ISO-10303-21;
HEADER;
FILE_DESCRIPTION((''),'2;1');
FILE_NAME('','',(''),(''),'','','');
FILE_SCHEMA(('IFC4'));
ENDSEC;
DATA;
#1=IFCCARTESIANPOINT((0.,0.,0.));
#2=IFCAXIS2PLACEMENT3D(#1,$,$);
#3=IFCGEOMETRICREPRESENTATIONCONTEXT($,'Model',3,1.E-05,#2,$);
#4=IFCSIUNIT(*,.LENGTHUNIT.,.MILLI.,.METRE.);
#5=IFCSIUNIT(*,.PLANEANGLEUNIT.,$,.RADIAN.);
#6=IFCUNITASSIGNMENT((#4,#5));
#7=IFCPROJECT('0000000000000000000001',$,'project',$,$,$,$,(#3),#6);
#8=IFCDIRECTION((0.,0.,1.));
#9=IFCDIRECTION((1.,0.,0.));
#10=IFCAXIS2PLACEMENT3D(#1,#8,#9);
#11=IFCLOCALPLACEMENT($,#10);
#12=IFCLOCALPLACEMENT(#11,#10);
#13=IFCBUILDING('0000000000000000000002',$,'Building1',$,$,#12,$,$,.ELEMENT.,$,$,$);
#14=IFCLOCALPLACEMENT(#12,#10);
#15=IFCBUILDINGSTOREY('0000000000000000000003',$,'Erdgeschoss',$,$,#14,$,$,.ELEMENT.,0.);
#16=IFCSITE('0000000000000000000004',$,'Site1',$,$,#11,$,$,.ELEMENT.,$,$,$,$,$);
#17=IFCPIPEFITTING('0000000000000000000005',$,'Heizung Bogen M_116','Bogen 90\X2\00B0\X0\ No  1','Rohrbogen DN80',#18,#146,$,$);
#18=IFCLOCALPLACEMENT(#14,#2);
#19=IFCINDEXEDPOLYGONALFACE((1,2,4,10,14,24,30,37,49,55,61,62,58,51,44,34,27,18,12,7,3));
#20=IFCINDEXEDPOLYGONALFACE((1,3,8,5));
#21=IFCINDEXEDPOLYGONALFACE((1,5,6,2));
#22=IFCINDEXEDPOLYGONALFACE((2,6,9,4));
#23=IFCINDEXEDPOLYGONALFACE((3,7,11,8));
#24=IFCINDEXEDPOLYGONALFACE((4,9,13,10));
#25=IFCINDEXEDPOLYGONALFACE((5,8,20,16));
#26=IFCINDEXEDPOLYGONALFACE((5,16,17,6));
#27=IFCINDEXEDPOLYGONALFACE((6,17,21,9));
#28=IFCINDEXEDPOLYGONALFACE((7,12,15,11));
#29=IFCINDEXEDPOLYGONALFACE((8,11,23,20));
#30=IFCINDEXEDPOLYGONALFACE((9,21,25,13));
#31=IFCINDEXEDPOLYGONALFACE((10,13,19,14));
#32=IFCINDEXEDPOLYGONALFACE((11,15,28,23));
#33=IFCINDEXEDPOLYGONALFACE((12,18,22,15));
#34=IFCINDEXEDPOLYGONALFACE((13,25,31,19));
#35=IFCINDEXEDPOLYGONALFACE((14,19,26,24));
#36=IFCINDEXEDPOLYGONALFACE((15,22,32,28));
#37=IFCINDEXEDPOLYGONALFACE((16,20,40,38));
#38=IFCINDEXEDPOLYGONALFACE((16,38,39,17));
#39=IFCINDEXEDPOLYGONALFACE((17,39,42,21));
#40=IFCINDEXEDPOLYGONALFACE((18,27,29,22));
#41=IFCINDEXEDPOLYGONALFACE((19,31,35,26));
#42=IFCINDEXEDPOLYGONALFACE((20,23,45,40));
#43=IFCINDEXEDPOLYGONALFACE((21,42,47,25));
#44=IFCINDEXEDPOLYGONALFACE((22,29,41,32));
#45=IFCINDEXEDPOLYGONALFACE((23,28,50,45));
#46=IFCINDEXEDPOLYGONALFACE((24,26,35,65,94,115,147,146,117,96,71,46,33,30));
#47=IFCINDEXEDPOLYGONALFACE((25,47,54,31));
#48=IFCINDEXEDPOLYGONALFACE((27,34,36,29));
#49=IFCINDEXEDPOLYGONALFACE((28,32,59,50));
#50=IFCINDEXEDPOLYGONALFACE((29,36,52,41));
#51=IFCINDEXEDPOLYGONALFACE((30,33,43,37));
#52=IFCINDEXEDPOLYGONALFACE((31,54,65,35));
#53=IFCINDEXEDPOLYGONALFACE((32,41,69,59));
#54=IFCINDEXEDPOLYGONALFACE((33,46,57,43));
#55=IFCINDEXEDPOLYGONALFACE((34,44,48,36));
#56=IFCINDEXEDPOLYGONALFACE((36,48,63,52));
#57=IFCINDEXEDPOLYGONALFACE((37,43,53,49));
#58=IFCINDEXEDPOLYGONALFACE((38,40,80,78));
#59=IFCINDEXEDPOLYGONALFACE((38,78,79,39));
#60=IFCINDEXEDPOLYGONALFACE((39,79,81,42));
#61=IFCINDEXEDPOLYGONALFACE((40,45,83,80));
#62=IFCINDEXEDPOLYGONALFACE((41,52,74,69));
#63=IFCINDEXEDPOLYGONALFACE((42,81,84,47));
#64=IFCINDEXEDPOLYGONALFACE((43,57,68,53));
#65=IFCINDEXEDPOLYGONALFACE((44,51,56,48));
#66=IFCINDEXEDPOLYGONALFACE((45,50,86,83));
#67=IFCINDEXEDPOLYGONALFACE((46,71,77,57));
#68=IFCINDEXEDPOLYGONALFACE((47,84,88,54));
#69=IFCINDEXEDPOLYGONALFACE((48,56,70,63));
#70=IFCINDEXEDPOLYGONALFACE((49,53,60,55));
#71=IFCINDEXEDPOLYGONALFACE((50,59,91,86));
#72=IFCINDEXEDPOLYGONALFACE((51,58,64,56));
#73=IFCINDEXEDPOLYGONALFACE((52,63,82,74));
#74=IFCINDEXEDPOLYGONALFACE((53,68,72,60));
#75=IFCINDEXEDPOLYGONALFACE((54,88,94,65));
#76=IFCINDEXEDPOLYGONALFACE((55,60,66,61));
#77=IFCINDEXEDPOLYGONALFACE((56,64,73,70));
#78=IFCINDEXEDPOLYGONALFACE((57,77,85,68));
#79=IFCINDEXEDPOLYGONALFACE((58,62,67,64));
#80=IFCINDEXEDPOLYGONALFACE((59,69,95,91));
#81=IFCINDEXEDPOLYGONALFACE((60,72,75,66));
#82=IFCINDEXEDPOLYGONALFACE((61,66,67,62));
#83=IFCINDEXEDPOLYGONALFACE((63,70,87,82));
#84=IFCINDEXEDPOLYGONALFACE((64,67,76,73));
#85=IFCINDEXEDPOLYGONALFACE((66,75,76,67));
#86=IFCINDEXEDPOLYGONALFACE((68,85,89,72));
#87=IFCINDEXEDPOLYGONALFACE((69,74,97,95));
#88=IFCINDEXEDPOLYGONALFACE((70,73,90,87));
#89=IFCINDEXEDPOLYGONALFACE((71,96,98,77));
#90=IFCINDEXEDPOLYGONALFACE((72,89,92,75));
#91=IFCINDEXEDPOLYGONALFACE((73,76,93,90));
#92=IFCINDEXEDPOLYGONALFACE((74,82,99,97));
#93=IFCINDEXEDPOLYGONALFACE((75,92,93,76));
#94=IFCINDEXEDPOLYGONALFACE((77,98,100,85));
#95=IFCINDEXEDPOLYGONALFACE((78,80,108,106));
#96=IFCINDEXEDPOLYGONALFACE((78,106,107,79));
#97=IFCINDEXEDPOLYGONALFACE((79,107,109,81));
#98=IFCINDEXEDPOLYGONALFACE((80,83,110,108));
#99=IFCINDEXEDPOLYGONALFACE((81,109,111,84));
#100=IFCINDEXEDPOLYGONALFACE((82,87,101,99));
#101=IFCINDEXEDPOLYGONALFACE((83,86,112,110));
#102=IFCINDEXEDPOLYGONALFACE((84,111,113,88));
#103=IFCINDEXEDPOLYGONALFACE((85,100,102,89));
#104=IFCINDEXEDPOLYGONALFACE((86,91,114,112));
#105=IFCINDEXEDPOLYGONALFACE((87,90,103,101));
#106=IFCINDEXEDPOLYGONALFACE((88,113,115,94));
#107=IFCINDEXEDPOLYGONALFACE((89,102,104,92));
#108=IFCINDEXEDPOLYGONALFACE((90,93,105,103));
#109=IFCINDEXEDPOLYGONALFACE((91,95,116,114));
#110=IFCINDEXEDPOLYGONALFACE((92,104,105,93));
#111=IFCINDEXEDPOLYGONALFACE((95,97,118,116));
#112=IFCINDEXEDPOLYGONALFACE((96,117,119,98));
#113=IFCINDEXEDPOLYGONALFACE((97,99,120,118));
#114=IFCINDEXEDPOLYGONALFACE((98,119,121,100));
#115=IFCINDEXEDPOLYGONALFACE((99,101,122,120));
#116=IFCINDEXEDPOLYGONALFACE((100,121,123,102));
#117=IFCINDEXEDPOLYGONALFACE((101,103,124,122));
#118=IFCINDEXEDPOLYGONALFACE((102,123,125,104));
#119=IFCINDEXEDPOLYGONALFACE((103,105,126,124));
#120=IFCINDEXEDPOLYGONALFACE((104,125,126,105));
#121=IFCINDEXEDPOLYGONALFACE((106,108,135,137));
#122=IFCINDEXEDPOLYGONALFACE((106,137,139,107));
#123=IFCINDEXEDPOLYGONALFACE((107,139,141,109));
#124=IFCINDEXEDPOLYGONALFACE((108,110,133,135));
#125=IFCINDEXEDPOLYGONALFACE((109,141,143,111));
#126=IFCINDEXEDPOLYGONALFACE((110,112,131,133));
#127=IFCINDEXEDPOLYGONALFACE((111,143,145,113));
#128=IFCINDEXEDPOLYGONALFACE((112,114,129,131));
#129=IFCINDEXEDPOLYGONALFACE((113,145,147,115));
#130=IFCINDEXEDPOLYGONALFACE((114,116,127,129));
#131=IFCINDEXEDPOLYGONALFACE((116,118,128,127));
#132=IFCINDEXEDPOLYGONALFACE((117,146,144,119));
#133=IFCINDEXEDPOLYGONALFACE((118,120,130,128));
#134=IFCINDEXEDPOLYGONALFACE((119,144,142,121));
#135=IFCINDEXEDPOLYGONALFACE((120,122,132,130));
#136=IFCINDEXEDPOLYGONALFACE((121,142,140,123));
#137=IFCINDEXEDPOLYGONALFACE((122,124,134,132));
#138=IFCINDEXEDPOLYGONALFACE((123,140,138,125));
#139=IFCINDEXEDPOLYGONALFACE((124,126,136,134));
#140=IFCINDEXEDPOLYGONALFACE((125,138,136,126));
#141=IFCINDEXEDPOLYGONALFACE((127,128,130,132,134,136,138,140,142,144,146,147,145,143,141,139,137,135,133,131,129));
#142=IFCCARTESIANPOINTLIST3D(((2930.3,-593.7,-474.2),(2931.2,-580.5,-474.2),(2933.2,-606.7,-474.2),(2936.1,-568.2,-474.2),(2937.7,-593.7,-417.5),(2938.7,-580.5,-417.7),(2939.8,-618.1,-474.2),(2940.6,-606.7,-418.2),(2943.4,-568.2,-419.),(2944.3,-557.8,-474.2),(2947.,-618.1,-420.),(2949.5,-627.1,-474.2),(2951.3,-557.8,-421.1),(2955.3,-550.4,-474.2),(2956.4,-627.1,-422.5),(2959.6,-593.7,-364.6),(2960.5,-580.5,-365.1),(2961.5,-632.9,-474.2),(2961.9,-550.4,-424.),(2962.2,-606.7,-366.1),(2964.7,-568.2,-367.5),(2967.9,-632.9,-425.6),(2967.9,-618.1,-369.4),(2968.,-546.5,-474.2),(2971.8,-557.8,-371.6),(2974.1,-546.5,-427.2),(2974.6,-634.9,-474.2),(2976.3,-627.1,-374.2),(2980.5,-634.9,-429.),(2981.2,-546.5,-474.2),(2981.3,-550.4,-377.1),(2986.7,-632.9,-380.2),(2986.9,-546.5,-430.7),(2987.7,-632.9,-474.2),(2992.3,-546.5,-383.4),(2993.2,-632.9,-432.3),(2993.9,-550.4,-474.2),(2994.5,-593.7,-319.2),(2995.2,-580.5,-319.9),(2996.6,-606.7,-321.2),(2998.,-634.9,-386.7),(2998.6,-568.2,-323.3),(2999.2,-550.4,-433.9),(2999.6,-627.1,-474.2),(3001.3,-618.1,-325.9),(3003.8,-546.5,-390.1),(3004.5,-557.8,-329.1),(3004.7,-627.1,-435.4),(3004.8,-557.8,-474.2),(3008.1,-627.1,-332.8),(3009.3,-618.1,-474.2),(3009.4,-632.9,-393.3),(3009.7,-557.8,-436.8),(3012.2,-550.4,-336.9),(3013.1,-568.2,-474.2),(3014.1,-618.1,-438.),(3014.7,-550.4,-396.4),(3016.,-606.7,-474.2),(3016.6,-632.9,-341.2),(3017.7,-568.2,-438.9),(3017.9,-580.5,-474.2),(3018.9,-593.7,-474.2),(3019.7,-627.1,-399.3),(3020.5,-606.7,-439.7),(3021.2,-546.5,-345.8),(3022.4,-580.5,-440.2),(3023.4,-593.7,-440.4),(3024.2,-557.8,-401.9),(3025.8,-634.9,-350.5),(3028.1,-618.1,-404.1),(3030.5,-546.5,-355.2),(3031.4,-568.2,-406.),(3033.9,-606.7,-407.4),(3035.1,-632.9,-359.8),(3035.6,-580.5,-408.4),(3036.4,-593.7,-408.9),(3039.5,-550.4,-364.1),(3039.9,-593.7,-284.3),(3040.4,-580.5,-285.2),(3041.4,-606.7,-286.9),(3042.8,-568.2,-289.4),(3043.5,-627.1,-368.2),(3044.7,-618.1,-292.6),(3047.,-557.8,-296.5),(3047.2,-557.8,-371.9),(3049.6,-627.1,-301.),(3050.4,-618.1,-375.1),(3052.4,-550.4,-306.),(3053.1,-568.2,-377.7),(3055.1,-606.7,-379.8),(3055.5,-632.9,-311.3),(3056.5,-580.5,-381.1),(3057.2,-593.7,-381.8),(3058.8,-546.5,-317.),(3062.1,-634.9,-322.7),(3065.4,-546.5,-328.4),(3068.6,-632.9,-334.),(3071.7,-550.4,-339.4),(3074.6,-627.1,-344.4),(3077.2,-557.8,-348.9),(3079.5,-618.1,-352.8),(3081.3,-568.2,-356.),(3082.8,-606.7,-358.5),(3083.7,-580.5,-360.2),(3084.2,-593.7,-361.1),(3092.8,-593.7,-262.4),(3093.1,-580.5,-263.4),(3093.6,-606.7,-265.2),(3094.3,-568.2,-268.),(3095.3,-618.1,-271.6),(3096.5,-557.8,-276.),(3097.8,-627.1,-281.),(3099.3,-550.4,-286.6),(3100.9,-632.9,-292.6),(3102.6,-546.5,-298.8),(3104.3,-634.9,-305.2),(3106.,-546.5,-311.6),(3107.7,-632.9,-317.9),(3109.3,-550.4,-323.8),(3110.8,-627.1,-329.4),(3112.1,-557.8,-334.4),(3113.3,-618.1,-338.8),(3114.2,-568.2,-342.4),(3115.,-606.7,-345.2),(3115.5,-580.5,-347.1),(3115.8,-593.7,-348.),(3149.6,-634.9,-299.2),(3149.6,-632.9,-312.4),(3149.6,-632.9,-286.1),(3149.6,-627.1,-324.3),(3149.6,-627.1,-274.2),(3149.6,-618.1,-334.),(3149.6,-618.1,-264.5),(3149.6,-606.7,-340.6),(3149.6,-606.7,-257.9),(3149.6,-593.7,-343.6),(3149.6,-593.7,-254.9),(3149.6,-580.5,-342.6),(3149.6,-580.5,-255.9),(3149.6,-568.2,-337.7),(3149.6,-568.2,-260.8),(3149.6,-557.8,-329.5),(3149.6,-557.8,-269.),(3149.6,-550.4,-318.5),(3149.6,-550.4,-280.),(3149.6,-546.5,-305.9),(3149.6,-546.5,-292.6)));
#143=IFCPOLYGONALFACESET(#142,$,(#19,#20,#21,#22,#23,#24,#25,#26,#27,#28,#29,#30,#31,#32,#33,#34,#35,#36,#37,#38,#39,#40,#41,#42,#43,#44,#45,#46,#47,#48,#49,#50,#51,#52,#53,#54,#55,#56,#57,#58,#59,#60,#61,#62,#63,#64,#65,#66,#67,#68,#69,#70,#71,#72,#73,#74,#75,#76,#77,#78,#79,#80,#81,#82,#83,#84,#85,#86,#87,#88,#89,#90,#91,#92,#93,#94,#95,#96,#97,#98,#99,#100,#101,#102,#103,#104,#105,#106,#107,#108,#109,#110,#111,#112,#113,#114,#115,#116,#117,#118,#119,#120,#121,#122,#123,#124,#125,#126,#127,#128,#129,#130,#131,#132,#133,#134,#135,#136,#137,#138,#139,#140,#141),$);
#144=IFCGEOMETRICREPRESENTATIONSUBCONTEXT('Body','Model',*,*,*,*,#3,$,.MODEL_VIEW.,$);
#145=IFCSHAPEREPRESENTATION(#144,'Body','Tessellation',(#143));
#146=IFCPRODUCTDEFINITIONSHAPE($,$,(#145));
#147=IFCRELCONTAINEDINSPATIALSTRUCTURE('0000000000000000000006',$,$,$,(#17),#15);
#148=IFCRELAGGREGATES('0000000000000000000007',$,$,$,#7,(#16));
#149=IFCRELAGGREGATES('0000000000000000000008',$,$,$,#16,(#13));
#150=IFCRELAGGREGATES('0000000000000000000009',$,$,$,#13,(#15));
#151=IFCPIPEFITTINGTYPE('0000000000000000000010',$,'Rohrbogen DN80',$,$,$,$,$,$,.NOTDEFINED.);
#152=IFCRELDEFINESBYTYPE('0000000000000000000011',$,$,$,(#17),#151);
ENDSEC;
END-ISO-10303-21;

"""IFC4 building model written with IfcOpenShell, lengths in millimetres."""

from ifc_helpers import new_model, entity, si_unit, frame, origin, origin_with_axes, place, context, subcontext, project, spatial, shape, source, transform, mapped, type_object, element, save


model = new_model("IFC4")

# Units and contexts
model_context = context("Model", 3, precision=1e-05, world=origin())
body_context = subcontext(model_context, "Body", "Model", "MODEL_VIEW")
ifc_project = project(units=[si_unit("LENGTHUNIT", "METRE", prefix="MILLI"), si_unit("PLANEANGLEUNIT", "RADIAN")], contexts=[model_context])

# Site, building, storey
site_placement = place(None, origin_with_axes())
site = spatial("IfcSite", under=ifc_project, at=site_placement, Name="Site1", CompositionType="ELEMENT")
building_placement = place(site_placement, origin_with_axes())
building = spatial("IfcBuilding", under=site, at=building_placement, Name="Building1", CompositionType="ELEMENT")
storey_placement = place(building_placement, origin_with_axes())
storey = spatial("IfcBuildingStorey", under=building, at=storey_placement, Name="Erdgeschoss", CompositionType="ELEMENT", Elevation=0.0)

# Shared definitions
pipe_fitting_type_1 = type_object("IfcPipeFittingType", Name="Rohrbogen DN80", PredefinedType="NOTDEFINED")

# Pipe fitting
shared_shape_1 = source(origin_with_axes(), body_context, "Body", "SolidModel", [
    entity("IfcRevolvedAreaSolid", entity("IfcCircleProfileDef", "AREA", None, entity("IfcAxis2Placement2D", entity("IfcCartesianPoint", [0.0, 0.0]), entity("IfcDirection", [1.0, 0.0])), 44.5), entity("IfcAxis2Placement3D", entity("IfcCartesianPoint", [109.7, -65.3, 0.0]), entity("IfcDirection", [-1.0, 0.0, 0.0]), entity("IfcDirection", [0.0, 0.0, 1.0])), entity("IfcAxis1Placement", entity("IfcCartesianPoint", [0.0, 175.0, 0.0]), entity("IfcDirection", [-1.0, 0.0, 0.0])), 1.570796),
])
pipe_fitting_1_placement = place(storey_placement, frame((3039.9, -590.4, -364.5), z_axis=(0.0, 0.0, 1.0), x_axis=(1.0, 0.0, 0.0)))
element("IfcPipeFitting", 1, at=pipe_fitting_1_placement, inside=storey, type_object=pipe_fitting_type_1, Name="Heizung Bogen M_116", Description="Bogen 90° No  1", ObjectType="Rohrbogen DN80", shapes=[
    shape(body_context, "Body", "MappedRepresentation", [mapped(shared_shape_1, transform((0.0, 0.0, 0.0), x_axis=(0.0, 0.0, -1.0), y_axis=(1.0, 0.0, 0.0), z_axis=(0.0, -1.0, 0.0), scale=1.0))]),
    shape(body_context, "Body", "MappedRepresentation", [mapped(shared_shape_1, transform((0.0, 0.0, 0.0), x_axis=(0.0, 0.0, -1.0), y_axis=(1.0, 0.0, 0.0), z_axis=(0.0, -1.0, 0.0), scale=1.0))]),
])

save(model, "model.ifc")
